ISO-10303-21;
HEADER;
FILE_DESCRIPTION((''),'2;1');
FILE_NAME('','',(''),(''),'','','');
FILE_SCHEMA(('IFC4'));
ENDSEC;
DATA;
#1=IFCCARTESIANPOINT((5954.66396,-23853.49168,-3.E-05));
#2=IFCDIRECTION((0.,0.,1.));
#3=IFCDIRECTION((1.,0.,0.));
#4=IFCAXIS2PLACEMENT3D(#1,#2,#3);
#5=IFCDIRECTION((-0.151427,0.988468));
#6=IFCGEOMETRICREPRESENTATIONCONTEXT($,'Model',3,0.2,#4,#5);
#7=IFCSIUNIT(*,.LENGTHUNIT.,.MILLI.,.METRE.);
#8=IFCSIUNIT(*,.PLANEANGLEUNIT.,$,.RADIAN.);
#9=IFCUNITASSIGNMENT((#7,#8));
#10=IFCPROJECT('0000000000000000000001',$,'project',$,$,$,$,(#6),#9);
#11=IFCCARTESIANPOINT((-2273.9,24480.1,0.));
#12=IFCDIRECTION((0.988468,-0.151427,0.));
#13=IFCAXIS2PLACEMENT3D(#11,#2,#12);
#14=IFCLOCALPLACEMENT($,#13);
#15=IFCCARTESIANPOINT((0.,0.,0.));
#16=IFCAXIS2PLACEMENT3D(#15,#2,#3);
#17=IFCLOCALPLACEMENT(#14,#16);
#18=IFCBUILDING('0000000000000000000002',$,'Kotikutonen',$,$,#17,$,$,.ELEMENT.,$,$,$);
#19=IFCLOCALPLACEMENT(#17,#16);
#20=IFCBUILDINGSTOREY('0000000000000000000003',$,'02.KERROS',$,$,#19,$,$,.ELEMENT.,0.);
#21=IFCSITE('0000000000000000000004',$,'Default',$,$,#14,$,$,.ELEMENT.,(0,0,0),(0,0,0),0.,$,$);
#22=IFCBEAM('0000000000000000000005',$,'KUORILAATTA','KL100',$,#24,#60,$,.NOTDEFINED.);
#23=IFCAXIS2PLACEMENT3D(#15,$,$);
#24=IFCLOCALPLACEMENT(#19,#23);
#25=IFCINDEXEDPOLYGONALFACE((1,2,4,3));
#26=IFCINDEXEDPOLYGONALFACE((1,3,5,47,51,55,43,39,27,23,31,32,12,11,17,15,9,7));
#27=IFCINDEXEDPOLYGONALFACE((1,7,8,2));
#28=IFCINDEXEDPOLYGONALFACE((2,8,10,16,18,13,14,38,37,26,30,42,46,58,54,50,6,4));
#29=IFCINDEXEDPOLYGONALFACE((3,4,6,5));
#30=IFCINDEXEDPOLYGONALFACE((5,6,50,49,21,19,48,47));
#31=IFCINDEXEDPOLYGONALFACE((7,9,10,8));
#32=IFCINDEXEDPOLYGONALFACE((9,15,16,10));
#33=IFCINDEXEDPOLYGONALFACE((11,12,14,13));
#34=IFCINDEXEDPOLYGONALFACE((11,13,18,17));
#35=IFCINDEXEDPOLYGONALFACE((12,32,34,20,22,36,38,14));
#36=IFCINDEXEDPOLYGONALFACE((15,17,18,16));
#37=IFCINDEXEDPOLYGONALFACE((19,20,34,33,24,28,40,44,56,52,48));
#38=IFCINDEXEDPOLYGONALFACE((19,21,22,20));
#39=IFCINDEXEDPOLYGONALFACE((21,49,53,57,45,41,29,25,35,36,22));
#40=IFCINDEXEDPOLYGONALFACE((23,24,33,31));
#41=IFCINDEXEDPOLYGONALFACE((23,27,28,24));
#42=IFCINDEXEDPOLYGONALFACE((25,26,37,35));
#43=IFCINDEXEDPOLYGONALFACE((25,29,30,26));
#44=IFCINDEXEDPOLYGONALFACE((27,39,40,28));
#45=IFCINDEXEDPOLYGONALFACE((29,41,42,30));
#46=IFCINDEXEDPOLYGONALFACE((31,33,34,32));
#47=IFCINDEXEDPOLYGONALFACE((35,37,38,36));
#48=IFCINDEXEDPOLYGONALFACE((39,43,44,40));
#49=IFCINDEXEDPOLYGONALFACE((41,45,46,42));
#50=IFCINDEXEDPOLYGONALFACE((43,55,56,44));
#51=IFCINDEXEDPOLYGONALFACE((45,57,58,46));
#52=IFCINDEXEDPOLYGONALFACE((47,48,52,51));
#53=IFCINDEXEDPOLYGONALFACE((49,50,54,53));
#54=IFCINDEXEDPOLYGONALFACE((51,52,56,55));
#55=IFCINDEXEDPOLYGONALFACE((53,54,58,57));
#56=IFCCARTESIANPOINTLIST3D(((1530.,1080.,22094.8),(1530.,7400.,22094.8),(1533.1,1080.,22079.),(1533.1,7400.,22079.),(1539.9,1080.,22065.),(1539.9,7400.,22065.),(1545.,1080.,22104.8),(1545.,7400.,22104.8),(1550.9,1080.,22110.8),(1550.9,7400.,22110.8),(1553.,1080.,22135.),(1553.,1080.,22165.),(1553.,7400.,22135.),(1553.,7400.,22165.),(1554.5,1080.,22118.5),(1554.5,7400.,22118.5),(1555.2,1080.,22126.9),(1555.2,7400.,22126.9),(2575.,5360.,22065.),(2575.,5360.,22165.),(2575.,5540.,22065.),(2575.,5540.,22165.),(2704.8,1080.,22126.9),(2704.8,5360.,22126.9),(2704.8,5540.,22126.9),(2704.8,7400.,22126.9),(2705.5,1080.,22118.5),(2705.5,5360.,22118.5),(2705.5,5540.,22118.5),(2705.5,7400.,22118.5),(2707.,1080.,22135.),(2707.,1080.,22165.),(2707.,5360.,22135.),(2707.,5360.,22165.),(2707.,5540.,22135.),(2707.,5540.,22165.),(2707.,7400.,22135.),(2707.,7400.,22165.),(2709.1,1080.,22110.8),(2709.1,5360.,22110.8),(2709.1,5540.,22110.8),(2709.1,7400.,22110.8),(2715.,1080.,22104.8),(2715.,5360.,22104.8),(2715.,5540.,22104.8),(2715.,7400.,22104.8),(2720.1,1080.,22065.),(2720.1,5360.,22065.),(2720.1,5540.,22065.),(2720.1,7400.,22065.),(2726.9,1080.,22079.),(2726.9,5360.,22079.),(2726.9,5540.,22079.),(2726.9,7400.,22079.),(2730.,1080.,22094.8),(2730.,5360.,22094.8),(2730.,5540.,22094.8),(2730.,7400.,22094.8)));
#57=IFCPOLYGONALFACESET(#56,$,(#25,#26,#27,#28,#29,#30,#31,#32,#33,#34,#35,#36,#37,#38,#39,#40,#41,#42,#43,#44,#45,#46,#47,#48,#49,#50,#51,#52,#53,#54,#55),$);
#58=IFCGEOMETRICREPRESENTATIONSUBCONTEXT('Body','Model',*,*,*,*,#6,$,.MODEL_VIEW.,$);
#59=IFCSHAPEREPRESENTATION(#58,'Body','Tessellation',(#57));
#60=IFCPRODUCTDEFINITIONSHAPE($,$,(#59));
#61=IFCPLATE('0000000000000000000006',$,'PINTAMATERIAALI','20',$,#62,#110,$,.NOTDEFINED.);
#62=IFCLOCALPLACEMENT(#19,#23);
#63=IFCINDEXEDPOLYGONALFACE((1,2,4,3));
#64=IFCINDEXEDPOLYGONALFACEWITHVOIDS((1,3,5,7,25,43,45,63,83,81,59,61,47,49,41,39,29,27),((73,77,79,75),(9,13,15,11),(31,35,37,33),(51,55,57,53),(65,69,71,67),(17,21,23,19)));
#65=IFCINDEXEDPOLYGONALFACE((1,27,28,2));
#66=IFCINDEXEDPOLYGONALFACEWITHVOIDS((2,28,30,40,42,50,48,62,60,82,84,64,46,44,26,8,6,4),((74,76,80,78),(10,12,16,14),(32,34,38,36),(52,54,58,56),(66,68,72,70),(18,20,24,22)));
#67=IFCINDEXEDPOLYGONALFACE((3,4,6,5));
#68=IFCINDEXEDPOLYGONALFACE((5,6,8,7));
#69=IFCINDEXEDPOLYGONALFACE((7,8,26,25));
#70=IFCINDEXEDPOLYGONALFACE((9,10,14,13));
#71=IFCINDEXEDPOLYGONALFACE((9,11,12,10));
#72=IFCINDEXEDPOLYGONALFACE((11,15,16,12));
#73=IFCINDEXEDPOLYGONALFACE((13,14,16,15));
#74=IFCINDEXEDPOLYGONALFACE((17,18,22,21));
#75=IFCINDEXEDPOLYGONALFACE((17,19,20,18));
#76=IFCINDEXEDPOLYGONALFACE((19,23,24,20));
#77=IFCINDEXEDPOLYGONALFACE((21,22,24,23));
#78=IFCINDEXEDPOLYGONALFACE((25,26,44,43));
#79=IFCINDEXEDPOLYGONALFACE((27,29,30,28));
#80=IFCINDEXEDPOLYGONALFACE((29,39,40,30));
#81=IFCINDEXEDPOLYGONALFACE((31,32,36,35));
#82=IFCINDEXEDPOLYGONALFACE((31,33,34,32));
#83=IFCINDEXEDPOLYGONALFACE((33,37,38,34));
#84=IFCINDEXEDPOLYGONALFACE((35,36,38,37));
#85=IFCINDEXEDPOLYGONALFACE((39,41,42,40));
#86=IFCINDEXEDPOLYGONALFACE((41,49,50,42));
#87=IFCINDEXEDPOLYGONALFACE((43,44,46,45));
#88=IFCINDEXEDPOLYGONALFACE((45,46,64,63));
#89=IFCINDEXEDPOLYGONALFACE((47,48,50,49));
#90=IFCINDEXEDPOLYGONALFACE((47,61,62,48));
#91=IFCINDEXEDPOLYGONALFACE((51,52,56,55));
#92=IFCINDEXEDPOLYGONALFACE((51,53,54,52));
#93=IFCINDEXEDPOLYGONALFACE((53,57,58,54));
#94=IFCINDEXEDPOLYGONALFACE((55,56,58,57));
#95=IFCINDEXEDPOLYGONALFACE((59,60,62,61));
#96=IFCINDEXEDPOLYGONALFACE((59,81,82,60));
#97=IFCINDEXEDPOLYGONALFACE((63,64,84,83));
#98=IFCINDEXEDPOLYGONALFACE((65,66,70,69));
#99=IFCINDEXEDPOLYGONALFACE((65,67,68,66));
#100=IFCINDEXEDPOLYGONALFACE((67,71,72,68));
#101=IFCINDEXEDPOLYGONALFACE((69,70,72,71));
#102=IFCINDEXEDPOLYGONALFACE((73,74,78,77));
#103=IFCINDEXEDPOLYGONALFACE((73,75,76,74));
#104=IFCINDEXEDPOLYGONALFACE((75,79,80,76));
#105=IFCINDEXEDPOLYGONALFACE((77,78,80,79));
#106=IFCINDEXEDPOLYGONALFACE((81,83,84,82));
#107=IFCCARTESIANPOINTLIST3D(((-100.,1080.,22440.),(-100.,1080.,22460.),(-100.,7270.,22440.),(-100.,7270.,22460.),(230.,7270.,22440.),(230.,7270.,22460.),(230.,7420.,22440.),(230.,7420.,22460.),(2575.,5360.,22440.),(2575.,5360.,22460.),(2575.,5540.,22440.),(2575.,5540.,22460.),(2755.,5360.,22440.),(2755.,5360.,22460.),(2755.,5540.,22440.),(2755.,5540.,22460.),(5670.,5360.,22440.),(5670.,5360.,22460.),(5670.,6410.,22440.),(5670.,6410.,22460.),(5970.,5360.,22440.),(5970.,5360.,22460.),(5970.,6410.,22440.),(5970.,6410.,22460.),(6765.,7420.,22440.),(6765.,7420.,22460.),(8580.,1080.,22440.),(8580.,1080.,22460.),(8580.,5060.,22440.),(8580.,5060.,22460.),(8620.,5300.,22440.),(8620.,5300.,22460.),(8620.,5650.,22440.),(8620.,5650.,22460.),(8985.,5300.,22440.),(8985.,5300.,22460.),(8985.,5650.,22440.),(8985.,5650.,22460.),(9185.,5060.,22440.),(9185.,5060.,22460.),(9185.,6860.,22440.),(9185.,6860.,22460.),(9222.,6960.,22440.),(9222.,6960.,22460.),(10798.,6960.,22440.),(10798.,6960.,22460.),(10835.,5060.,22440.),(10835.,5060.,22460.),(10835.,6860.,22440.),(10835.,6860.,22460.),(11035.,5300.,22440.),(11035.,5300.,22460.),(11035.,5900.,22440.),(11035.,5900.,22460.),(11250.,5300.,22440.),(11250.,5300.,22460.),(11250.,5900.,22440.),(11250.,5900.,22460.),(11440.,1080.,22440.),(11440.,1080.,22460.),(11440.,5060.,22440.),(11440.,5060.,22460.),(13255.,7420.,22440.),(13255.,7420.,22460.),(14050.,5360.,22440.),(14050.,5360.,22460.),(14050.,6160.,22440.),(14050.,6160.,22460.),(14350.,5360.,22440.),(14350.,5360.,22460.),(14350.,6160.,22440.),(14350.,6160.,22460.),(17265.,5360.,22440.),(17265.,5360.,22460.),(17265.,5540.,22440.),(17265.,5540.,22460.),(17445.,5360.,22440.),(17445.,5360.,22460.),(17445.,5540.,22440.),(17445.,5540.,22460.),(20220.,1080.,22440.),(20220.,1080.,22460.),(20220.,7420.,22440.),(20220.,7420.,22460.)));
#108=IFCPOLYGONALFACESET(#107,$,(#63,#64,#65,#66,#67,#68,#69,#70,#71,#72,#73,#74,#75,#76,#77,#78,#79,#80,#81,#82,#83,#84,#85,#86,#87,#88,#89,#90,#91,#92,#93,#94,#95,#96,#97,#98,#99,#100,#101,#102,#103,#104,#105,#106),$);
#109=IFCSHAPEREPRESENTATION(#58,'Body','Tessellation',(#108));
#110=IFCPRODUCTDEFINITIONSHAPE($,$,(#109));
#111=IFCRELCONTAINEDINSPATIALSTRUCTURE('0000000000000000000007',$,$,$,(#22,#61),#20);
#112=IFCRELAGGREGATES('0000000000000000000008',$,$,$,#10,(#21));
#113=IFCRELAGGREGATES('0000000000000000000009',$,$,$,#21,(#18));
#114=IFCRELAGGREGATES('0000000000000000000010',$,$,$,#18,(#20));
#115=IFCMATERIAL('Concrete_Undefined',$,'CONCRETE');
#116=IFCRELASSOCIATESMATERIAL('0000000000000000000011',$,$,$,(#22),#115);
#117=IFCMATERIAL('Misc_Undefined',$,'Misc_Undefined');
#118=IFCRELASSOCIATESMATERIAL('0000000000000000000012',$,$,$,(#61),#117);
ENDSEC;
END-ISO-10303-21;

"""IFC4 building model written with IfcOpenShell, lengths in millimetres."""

from ifc_helpers import new_model, si_unit, direction, frame, origin_with_axes, place, context, subcontext, project, spatial, line, indexed_curve, outline, extrude, material, element, save


model = new_model("IFC4")

# Units and contexts
model_context = context("Model", 3, precision=0.2, world=frame((5954.66396, -23853.49168, -3e-05), z_axis=(0.0, 0.0, 1.0), x_axis=(1.0, 0.0, 0.0)), true_north=direction((-0.151427, 0.988468)))
body_context = subcontext(model_context, "Body", "Model", "MODEL_VIEW")
ifc_project = project(units=[si_unit("LENGTHUNIT", "METRE", prefix="MILLI"), si_unit("PLANEANGLEUNIT", "RADIAN")], contexts=[model_context])

# Site, building, storey
site_placement = place(None, frame((-2273.9, 24480.1, 0.0), z_axis=(0.0, 0.0, 1.0), x_axis=(0.988468, -0.151427, 0.0)))
site = spatial("IfcSite", under=ifc_project, at=site_placement, Name="Default", CompositionType="ELEMENT", RefLatitude=(0, 0, 0), RefLongitude=(0, 0, 0), RefElevation=0.0)
building_placement = place(site_placement, origin_with_axes())
building = spatial("IfcBuilding", under=site, at=building_placement, Name="Kotikutonen", CompositionType="ELEMENT")
storey_placement = place(building_placement, origin_with_axes())
storey = spatial("IfcBuildingStorey", under=building, at=storey_placement, Name="02.KERROS", CompositionType="ELEMENT", Elevation=0.0)

# Shared definitions
ifc_material_1 = material(Name="Concrete_Undefined", Category="CONCRETE")

# Beam, voiding feature
beam_1_placement = place(storey_placement, frame((2130.0, 7400.0, 22115.0), z_axis=(-1.0, 0.0, 0.0), x_axis=(0.0, -1.0, 0.0)))
beam_1 = element("IfcBeam", 1, at=beam_1_placement, inside=storey, material=ifc_material_1, Name="KUORILAATTA", Description="KL100", PredefinedType="NOTDEFINED", context=body_context, shape_type="SolidModel", body=[
    extrude(outline(indexed_curve([(-596.9, -36.0), (-590.1, -50.0), (590.1, -50.0), (596.9, -36.0), (600.0, -20.2), (585.0, -10.2), (579.1, -4.2), (575.5, 3.5), (574.8, 11.9), (577.0, 20.0), (577.0, 50.0), (-577.0, 50.0), (-577.0, 20.0), (-574.8, 11.9), (-575.5, 3.5), (-579.1, -4.2), (-585.0, -10.2), (-600.0, -20.2)], segments=[line(1, 2, 3, 4, 5, 6, 7, 8, 9, 10, 11, 12, 13, 14, 15, 16, 17, 18, 1)])), frame((0.0, 0.0, 0.0), z_axis=(-1.0, 0.0, 0.0), x_axis=(0.0, 0.0, 1.0)), (0.0, 0.0, -1.0), 6320.0),
])
voiding_feature_1_placement = place(beam_1_placement, frame((2040.0, 0.0, -445.0), z_axis=(0.0, 1.0, 0.0), x_axis=(0.0, 0.0, -1.0)))
element("IfcVoidingFeature", 2, at=voiding_feature_1_placement, cuts=beam_1, Name="Opening", PredefinedType="HOLE", context=body_context, shape_type="SolidModel", body=[
    extrude(outline(indexed_curve([(0.0, 0.0), (405.0, 0.0), (405.0, 180.0), (0.0, 180.0)], segments=[line(1, 2, 3, 4, 1)])), frame((0.0, 0.0, 125.0), z_axis=(0.0, 0.0, 1.0), x_axis=(1.0, 0.0, 0.0)), (0.0, 0.0, -1.0), 250.0),
])

# Plate, voiding features
ifc_material_2 = material(Name="Misc_Undefined", Category="Misc_Undefined")
plate_1_placement = place(storey_placement, frame((-100.0, 7270.0, 22450.0), z_axis=(0.0, 0.0, 1.0), x_axis=(0.0, -1.0, 0.0)))
plate_1 = element("IfcPlate", 3, at=plate_1_placement, inside=storey, material=ifc_material_2, Name="PINTAMATERIAALI", Description="20", PredefinedType="NOTDEFINED", context=body_context, shape_type="SolidModel", body=[
    extrude(outline(indexed_curve([(0.0, 0.0), (6190.0, 0.0), (6190.0, 8680.0), (7270.0, 8680.0), (7270.0, 11540.0), (6190.0, 11540.0), (6190.0, 20320.0), (-150.0, 20320.0), (-150.0, 13355.0), (310.0, 10898.0), (310.0, 9322.0), (-150.0, 6865.0), (-150.0, 330.0), (0.0, 330.0)], segments=[line(1, 2, 3, 4, 5, 6, 7, 8, 9, 10, 11, 12, 13, 14, 1)])), frame((0.0, 0.0, 10.0), z_axis=(0.0, 0.0, 1.0), x_axis=(1.0, 0.0, 0.0)), (0.0, 0.0, -1.0), 20.0),
])
voiding_feature_2_placement = place(plate_1_placement, frame((2210.0, 8680.0, 0.0), z_axis=(0.0, 0.0, 1.0), x_axis=(1.0, 0.0, 0.0)))
element("IfcVoidingFeature", 4, at=voiding_feature_2_placement, cuts=plate_1, Name="POLYGON CUT", PredefinedType="HOLE", context=body_context, shape_type="SolidModel", body=[
    extrude(outline(indexed_curve([(0.0, 0.0), (5060.0, 0.0), (5060.0, 2860.0), (0.0, 2860.0), (0.0, 2255.0), (-1800.0, 2255.0), (-1800.0, 605.0), (0.0, 605.0)], segments=[line(1, 2, 3, 4, 5, 6, 7, 8, 1)])), frame((0.0, 0.0, 85.0), z_axis=(0.0, 0.0, 1.0), x_axis=(1.0, 0.0, 0.0)), (0.0, 0.0, -1.0), 170.0),
])
voiding_feature_3_placement = place(plate_1_placement, frame((1620.0, 8720.0, 0.0), z_axis=(0.0, 0.0, 1.0), x_axis=(1.0, 0.0, 0.0)))
element("IfcVoidingFeature", 5, at=voiding_feature_3_placement, cuts=plate_1, Name="POLYGON CUT", PredefinedType="HOLE", context=body_context, shape_type="SolidModel", body=[
    extrude(outline(indexed_curve([(0.0, 0.0), (350.0, 0.0), (350.0, 365.0), (0.0, 365.0)], segments=[line(1, 2, 3, 4, 1)])), frame((0.0, 0.0, 85.0), z_axis=(0.0, 0.0, 1.0), x_axis=(1.0, 0.0, 0.0)), (0.0, 0.0, -1.0), 170.0),
])
voiding_feature_4_placement = place(plate_1_placement, frame((1370.0, 11135.0, 0.0), z_axis=(0.0, 0.0, 1.0), x_axis=(1.0, 0.0, 0.0)))
element("IfcVoidingFeature", 6, at=voiding_feature_4_placement, cuts=plate_1, Name="POLYGON CUT", PredefinedType="HOLE", context=body_context, shape_type="SolidModel", body=[
    extrude(outline(indexed_curve([(0.0, 0.0), (600.0, 0.0), (600.0, 215.0), (0.0, 215.0)], segments=[line(1, 2, 3, 4, 1)])), frame((0.0, 0.0, 85.0), z_axis=(0.0, 0.0, 1.0), x_axis=(1.0, 0.0, 0.0)), (0.0, 0.0, -1.0), 170.0),
])
voiding_feature_5_placement = place(plate_1_placement, frame((860.0, 5770.0, 0.0), z_axis=(0.0, 0.0, 1.0), x_axis=(1.0, 0.0, 0.0)))
element("IfcVoidingFeature", 7, at=voiding_feature_5_placement, cuts=plate_1, Name="POLYGON CUT", PredefinedType="HOLE", context=body_context, shape_type="SolidModel", body=[
    extrude(outline(indexed_curve([(0.0, 0.0), (1050.0, 0.0), (1050.0, 300.0), (0.0, 300.0)], segments=[line(1, 2, 3, 4, 1)])), frame((0.0, 0.0, 85.0), z_axis=(0.0, 0.0, 1.0), x_axis=(1.0, 0.0, 0.0)), (0.0, 0.0, -1.0), 170.0),
])
voiding_feature_6_placement = place(plate_1_placement, frame((1110.0, 14150.0, 0.0), z_axis=(0.0, 0.0, 1.0), x_axis=(1.0, 0.0, 0.0)))
element("IfcVoidingFeature", 8, at=voiding_feature_6_placement, cuts=plate_1, Name="POLYGON CUT", PredefinedType="HOLE", context=body_context, shape_type="SolidModel", body=[
    extrude(outline(indexed_curve([(0.0, 0.0), (800.0, 0.0), (800.0, 300.0), (0.0, 300.0)], segments=[line(1, 2, 3, 4, 1)])), frame((0.0, 0.0, 85.0), z_axis=(0.0, 0.0, 1.0), x_axis=(1.0, 0.0, 0.0)), (0.0, 0.0, -1.0), 170.0),
])
voiding_feature_7_placement = place(plate_1_placement, frame((1730.0, 2675.0, 0.0), z_axis=(0.0, 0.0, 1.0), x_axis=(1.0, 0.0, 0.0)))
element("IfcVoidingFeature", 9, at=voiding_feature_7_placement, cuts=plate_1, Name="POLYGON CUT", PredefinedType="HOLE", context=body_context, shape_type="SolidModel", body=[
    extrude(outline(indexed_curve([(0.0, 0.0), (180.0, 0.0), (180.0, 180.0), (0.0, 180.0)], segments=[line(1, 2, 3, 4, 1)])), frame((0.0, 0.0, 85.0), z_axis=(0.0, 0.0, 1.0), x_axis=(1.0, 0.0, 0.0)), (0.0, 0.0, -1.0), 170.0),
])
voiding_feature_8_placement = place(plate_1_placement, frame((1730.0, 17365.0, 0.0), z_axis=(0.0, 0.0, 1.0), x_axis=(1.0, 0.0, 0.0)))
element("IfcVoidingFeature", 10, at=voiding_feature_8_placement, cuts=plate_1, Name="POLYGON CUT", PredefinedType="HOLE", context=body_context, shape_type="SolidModel", body=[
    extrude(outline(indexed_curve([(0.0, 0.0), (180.0, 0.0), (180.0, 180.0), (0.0, 180.0)], segments=[line(1, 2, 3, 4, 1)])), frame((0.0, 0.0, 85.0), z_axis=(0.0, 0.0, 1.0), x_axis=(1.0, 0.0, 0.0)), (0.0, 0.0, -1.0), 170.0),
])

save(model, "model.ifc")
